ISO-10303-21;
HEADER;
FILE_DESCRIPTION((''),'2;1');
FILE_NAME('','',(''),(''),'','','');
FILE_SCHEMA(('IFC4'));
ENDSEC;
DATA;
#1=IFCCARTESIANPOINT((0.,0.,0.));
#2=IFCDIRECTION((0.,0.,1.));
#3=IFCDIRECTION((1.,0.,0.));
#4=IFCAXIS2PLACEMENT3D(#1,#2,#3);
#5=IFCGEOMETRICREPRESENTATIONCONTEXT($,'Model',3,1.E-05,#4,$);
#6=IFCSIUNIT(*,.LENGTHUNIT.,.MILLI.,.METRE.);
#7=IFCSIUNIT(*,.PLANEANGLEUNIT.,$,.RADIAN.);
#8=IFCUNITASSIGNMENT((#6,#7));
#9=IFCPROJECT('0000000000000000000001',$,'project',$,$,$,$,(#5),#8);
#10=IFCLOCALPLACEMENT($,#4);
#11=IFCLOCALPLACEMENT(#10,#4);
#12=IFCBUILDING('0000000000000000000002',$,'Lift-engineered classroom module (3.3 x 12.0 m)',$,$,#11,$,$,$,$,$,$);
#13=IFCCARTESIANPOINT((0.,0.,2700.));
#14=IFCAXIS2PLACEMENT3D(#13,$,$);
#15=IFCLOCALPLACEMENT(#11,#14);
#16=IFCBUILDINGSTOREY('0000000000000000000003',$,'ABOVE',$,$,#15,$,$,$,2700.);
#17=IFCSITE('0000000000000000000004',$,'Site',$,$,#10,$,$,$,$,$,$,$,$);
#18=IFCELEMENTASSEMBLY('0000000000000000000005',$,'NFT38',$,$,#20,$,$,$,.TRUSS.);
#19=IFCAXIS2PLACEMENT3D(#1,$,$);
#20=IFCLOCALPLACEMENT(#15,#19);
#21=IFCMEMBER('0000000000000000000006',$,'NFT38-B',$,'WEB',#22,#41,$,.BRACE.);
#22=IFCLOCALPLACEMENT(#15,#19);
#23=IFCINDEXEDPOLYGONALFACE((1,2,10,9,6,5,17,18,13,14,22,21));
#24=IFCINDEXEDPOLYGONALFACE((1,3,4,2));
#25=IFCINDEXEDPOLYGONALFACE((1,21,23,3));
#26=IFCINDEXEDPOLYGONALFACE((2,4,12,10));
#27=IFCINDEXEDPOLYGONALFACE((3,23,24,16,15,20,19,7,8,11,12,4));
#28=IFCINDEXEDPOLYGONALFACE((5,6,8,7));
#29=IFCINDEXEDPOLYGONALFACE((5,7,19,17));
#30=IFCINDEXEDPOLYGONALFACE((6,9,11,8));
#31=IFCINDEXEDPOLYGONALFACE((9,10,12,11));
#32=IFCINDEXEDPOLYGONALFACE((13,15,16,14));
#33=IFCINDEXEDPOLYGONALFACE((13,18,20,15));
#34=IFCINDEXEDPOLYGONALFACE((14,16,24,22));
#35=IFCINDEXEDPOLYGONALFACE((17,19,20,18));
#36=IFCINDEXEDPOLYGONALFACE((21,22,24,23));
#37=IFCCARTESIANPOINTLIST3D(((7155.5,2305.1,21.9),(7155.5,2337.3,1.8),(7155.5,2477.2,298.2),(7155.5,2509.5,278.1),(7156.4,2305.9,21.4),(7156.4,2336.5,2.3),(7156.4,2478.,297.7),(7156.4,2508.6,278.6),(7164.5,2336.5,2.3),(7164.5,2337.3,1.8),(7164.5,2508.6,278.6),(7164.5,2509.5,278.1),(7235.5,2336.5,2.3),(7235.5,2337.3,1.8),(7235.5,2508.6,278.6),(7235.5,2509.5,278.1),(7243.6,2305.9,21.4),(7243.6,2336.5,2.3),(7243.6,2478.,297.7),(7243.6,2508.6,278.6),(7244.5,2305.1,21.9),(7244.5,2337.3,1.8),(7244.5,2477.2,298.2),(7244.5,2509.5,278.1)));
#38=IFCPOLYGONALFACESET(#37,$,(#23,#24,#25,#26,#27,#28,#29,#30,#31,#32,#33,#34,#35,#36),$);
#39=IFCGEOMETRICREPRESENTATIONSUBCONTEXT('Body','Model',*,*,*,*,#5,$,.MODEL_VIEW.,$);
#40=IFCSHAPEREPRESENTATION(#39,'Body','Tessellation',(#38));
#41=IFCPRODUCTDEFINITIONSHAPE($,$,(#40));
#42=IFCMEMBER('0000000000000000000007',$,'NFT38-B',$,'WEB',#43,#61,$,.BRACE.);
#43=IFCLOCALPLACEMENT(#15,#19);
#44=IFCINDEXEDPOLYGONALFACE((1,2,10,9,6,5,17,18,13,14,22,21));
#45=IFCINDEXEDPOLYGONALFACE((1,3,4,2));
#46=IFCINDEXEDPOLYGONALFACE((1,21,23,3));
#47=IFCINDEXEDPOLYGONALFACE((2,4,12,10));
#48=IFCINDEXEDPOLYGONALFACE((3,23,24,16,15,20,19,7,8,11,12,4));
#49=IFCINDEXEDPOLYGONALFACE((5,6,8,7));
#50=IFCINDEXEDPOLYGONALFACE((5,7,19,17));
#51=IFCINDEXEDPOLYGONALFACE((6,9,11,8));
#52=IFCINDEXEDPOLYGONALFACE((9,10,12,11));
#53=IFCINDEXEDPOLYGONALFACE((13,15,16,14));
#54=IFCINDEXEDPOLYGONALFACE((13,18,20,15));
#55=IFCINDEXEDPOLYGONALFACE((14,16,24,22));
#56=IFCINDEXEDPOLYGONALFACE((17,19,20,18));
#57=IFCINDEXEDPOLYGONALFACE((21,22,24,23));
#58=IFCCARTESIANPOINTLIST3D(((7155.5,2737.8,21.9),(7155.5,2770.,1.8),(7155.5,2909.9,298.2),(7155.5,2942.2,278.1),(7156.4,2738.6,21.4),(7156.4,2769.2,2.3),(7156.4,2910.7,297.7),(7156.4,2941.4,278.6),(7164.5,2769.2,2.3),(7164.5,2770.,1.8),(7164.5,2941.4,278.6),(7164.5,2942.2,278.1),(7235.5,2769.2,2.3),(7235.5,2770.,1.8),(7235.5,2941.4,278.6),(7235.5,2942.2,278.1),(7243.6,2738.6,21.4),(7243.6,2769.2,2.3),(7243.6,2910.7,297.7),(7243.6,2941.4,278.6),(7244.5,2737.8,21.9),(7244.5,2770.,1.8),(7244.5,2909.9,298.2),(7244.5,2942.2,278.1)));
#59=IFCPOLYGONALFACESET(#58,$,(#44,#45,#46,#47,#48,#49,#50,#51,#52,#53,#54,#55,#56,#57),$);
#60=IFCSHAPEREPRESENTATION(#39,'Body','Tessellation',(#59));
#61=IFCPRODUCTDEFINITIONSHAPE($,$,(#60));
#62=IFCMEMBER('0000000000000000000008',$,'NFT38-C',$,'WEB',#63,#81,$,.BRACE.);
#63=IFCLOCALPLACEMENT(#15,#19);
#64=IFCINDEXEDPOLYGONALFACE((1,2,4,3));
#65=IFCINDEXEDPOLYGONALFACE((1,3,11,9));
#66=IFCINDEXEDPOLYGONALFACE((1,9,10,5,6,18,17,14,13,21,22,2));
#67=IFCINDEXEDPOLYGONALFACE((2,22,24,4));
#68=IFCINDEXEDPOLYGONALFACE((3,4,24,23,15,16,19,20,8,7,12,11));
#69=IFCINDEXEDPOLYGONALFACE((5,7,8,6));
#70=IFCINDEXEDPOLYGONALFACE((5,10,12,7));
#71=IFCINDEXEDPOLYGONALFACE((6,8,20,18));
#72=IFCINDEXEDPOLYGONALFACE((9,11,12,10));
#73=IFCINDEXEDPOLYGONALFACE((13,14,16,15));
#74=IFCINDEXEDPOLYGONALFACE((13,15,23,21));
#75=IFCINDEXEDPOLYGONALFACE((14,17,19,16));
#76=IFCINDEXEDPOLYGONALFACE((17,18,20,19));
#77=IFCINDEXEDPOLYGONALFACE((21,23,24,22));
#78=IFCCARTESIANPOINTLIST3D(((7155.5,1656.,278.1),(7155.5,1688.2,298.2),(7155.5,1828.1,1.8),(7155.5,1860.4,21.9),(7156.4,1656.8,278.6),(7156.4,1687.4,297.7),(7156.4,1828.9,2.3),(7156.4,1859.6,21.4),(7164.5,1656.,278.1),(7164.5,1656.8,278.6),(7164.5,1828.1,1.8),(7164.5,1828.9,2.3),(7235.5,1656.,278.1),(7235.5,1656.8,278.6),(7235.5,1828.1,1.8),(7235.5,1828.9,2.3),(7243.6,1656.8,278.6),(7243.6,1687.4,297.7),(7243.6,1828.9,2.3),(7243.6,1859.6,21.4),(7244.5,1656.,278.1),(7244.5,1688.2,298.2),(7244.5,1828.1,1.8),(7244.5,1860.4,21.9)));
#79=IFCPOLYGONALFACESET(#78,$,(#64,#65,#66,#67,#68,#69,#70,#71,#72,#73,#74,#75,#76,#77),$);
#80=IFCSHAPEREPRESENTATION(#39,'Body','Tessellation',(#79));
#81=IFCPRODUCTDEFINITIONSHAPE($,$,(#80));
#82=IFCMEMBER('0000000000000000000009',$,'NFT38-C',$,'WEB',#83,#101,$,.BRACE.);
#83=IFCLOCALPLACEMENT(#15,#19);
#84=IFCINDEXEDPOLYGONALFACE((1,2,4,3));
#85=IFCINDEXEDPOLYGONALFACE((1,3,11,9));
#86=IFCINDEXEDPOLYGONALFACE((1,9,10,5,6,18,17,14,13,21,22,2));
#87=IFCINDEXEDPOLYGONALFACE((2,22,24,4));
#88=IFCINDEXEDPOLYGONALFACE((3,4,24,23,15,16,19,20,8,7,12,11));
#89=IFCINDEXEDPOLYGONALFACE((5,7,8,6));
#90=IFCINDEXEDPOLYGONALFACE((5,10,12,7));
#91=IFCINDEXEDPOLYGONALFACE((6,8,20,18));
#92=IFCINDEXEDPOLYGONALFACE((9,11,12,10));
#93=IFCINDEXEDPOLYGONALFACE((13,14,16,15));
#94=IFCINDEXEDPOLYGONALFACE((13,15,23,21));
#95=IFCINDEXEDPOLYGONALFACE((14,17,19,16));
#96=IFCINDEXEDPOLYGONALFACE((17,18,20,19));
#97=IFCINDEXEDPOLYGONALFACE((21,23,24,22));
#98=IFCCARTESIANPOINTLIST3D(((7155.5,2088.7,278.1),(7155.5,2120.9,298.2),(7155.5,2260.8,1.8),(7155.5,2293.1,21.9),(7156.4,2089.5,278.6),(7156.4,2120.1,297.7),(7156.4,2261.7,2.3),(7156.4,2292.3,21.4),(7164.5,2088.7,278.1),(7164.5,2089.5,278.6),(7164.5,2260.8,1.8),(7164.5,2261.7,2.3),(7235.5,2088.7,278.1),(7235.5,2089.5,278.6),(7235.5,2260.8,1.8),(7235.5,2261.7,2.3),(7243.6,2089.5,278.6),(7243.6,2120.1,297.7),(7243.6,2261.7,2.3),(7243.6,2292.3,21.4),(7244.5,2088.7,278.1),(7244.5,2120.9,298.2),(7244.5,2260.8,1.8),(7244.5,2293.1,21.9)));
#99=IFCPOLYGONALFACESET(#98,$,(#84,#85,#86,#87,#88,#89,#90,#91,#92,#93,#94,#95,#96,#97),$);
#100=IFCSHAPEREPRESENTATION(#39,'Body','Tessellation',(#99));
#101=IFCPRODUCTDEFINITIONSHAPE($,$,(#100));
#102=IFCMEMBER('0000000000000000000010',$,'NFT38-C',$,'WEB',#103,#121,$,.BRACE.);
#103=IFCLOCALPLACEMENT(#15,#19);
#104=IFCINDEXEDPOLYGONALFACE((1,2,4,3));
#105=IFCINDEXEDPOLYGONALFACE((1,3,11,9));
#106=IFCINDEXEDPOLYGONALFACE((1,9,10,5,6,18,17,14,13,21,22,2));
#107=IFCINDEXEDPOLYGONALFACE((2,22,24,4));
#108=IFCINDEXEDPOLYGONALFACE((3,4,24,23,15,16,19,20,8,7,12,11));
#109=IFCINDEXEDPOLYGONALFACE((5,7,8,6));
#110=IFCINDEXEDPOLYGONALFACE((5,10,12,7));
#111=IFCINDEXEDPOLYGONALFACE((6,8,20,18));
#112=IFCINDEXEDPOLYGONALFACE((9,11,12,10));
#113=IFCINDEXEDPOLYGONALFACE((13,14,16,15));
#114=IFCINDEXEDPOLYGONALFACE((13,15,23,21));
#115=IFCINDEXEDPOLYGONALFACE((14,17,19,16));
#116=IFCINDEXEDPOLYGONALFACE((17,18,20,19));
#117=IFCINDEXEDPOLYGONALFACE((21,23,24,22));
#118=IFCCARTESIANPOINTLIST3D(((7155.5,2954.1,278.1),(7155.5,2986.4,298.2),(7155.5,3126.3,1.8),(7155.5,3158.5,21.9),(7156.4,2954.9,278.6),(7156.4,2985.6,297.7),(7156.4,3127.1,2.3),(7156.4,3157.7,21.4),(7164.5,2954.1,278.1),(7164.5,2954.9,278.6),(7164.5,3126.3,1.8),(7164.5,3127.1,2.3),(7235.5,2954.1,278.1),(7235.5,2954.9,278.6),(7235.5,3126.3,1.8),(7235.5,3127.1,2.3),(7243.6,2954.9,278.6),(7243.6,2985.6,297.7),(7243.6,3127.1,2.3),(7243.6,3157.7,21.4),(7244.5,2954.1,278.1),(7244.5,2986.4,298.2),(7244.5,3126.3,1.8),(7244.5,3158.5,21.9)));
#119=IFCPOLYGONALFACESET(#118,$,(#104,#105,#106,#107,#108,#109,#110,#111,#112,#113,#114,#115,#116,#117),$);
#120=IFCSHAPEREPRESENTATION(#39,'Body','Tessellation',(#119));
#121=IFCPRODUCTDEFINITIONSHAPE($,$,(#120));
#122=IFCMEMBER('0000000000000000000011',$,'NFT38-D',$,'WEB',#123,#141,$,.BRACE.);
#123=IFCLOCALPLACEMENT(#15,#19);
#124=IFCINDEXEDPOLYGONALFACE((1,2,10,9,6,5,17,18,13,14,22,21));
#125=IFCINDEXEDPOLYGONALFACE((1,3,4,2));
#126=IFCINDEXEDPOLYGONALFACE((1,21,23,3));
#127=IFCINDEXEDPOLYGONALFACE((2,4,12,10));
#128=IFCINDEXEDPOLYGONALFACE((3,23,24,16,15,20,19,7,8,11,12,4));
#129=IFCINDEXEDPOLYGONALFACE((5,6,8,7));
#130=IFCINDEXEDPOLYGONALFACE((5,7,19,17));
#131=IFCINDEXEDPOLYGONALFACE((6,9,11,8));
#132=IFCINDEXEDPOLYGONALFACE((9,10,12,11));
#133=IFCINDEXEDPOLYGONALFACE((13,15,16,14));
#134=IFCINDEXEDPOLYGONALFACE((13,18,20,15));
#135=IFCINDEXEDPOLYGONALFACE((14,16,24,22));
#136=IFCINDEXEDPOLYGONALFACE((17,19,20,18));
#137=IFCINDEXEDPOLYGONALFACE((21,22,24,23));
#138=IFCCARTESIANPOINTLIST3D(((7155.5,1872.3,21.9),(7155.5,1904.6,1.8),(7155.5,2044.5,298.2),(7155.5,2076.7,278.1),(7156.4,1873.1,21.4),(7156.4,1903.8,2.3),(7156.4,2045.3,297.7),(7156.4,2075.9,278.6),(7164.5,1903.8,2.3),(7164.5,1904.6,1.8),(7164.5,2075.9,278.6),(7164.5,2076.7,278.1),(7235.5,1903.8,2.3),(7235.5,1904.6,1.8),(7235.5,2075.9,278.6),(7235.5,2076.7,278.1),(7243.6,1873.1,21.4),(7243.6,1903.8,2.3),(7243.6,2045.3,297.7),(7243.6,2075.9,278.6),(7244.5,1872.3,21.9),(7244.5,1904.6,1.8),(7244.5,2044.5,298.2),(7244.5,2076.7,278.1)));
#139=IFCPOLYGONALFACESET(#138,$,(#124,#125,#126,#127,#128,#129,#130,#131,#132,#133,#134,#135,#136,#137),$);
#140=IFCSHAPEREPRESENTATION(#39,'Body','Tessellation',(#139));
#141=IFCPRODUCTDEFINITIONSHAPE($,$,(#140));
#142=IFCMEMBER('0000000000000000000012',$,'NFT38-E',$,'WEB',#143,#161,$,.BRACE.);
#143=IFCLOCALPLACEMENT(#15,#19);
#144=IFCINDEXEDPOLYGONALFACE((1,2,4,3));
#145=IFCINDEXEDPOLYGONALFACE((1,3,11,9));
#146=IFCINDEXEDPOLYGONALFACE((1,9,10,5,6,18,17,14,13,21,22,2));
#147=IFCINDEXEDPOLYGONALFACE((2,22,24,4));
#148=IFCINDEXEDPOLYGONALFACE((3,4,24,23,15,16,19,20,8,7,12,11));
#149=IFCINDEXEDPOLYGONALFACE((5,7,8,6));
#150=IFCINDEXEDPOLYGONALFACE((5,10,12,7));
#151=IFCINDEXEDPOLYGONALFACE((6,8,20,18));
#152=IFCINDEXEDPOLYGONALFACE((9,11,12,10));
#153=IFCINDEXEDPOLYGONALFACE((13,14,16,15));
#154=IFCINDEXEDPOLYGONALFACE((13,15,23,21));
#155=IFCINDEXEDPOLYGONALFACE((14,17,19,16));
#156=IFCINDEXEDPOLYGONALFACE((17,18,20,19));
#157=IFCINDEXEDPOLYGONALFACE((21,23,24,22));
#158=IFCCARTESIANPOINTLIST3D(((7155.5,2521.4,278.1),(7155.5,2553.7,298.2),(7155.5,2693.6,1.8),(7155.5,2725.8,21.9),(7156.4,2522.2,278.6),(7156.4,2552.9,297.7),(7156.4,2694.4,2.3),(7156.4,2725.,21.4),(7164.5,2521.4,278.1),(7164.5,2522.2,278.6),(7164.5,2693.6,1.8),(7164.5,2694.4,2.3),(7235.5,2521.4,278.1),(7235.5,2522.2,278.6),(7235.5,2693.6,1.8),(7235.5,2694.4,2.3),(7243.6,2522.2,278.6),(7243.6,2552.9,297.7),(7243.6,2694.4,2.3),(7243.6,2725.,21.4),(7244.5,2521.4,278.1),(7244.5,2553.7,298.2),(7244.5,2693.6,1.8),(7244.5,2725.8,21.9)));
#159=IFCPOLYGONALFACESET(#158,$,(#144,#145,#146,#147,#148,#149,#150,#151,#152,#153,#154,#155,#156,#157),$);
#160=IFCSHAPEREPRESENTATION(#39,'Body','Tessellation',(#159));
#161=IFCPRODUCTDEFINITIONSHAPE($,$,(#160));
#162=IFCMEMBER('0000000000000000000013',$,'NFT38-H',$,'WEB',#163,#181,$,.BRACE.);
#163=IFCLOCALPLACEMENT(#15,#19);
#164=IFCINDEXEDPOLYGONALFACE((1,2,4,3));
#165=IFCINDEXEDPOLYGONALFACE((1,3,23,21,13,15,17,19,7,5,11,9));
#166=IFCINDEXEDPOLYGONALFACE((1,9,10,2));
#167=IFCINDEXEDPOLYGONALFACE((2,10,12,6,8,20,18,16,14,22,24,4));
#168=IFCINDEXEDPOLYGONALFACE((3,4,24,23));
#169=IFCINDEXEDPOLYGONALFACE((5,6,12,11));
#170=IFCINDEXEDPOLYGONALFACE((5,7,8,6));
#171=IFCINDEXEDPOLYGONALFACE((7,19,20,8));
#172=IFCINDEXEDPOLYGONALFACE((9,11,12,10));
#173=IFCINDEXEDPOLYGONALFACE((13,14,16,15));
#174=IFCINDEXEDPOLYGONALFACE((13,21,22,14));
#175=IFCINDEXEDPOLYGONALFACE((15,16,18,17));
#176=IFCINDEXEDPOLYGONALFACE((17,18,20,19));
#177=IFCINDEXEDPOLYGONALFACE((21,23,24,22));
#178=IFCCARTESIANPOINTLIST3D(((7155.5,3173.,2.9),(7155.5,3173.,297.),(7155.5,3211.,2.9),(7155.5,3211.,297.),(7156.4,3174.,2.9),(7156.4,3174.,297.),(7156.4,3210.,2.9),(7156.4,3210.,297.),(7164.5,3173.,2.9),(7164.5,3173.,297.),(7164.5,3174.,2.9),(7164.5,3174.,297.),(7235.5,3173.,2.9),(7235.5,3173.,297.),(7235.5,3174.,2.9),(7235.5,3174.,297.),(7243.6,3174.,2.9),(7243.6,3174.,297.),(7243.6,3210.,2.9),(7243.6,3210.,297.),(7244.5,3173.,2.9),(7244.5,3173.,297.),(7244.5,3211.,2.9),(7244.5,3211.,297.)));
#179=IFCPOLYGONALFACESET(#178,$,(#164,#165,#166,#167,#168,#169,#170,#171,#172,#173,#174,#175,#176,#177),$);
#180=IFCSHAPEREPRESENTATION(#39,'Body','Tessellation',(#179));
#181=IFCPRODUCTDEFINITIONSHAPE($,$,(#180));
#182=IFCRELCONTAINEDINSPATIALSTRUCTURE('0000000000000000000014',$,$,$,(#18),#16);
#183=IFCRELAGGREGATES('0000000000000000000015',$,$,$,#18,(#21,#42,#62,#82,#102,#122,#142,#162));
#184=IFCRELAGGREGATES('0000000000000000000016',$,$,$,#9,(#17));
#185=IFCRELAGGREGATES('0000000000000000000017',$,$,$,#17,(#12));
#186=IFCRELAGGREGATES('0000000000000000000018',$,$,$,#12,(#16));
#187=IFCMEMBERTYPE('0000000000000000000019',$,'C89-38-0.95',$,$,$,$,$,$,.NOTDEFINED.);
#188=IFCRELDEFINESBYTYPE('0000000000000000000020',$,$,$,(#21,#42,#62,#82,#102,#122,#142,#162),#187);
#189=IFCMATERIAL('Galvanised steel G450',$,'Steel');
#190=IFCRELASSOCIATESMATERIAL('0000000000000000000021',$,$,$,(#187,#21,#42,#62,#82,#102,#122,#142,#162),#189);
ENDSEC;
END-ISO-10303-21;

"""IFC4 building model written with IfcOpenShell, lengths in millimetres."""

from ifc_helpers import new_model, si_unit, frame, origin, origin_with_axes, origin_2d, place, context, subcontext, project, spatial, c_section, extrude, material, material_profile, profile_set, profile_usage, type_object, element, aggregate, save


model = new_model("IFC4")

# Units and contexts
model_context = context("Model", 3, precision=1e-05, world=origin_with_axes())
body_context = subcontext(model_context, "Body", "Model", "MODEL_VIEW")
ifc_project = project(units=[si_unit("LENGTHUNIT", "METRE", prefix="MILLI"), si_unit("PLANEANGLEUNIT", "RADIAN")], contexts=[model_context])

# Site, building, storey
site_placement = place(None, origin_with_axes())
site = spatial("IfcSite", under=ifc_project, at=site_placement, Name="Site")
building_placement = place(site_placement, origin_with_axes())
building = spatial("IfcBuilding", under=site, at=building_placement, Name="Lift-engineered classroom module (3.3 x 12.0 m)")
storey_placement = place(building_placement, frame((0.0, 0.0, 2700.0)))
storey = spatial("IfcBuildingStorey", under=building, at=storey_placement, Name="ABOVE", Elevation=2700.0)

# Element assembly, members
ifc_material = material(Name="Galvanised steel G450", Category="Steel")
ifc_material_profile_1 = material_profile(ifc_material, c_section(Depth=89.0, Width=38.0, WallThickness=0.9, Girth=9.0, at=origin_2d()), Name="C89-38-0.95")
ifc_profile_set_1 = profile_set([ifc_material_profile_1], Name="C89-38-0.95")
ifc_profile_usage_1 = profile_usage(ifc_profile_set_1)
member_type_1 = type_object("IfcMemberType", Name="C89-38-0.95", PredefinedType="NOTDEFINED", material=ifc_profile_set_1)
assembly_1_placement = place(storey_placement, frame((7200.0, 89.0, 0.0)))
assembly_1 = element("IfcElementAssembly", 1, at=assembly_1_placement, inside=storey, Name="NFT38", PredefinedType="TRUSS")
member_1_placement = place(assembly_1_placement, frame((0.0, 2232.2, 11.8), z_axis=(0.0, 0.528797, 0.848748), x_axis=(0.0, 0.848748, -0.528797)))
member_1 = element("IfcMember", 2, at=member_1_placement, type_object=member_type_1, material=ifc_profile_usage_1, Name="NFT38-B", ObjectType="WEB", PredefinedType="BRACE", context=body_context, shape_type="SweptSolid", body=[
    extrude(c_section(Depth=89.0, Width=38.0, WallThickness=0.9, Girth=9.0, at=origin_2d()), origin(), (0.0, 0.0, 1.0), 325.6),
])
member_2_placement = place(assembly_1_placement, frame((0.0, 2664.9, 11.8), z_axis=(0.0, 0.528797, 0.848748), x_axis=(0.0, 0.848748, -0.528797)))
member_2 = element("IfcMember", 3, at=member_2_placement, type_object=member_type_1, material=ifc_profile_usage_1, Name="NFT38-B", ObjectType="WEB", PredefinedType="BRACE", context=body_context, shape_type="SweptSolid", body=[
    extrude(c_section(Depth=89.0, Width=38.0, WallThickness=0.9, Girth=9.0, at=origin_2d()), origin(), (0.0, 0.0, 1.0), 325.6),
])
member_3_placement = place(assembly_1_placement, frame((0.0, 1755.3, 11.8), z_axis=(0.0, -0.528797, 0.848748), x_axis=(0.0, -0.848748, -0.528797)))
member_3 = element("IfcMember", 4, at=member_3_placement, type_object=member_type_1, material=ifc_profile_usage_1, Name="NFT38-C", ObjectType="WEB", PredefinedType="BRACE", context=body_context, shape_type="SweptSolid", body=[
    extrude(c_section(Depth=89.0, Width=38.0, WallThickness=0.9, Girth=9.0, at=origin_2d()), origin(), (0.0, 0.0, 1.0), 325.6),
])
member_4_placement = place(assembly_1_placement, frame((0.0, 2188.0, 11.8), z_axis=(0.0, -0.528797, 0.848748), x_axis=(0.0, -0.848748, -0.528797)))
member_4 = element("IfcMember", 5, at=member_4_placement, type_object=member_type_1, material=ifc_profile_usage_1, Name="NFT38-C", ObjectType="WEB", PredefinedType="BRACE", context=body_context, shape_type="SweptSolid", body=[
    extrude(c_section(Depth=89.0, Width=38.0, WallThickness=0.9, Girth=9.0, at=origin_2d()), origin(), (0.0, 0.0, 1.0), 325.6),
])
member_5_placement = place(assembly_1_placement, frame((0.0, 3053.4, 11.8), z_axis=(0.0, -0.528797, 0.848748), x_axis=(0.0, -0.848748, -0.528797)))
member_5 = element("IfcMember", 6, at=member_5_placement, type_object=member_type_1, material=ifc_profile_usage_1, Name="NFT38-C", ObjectType="WEB", PredefinedType="BRACE", context=body_context, shape_type="SweptSolid", body=[
    extrude(c_section(Depth=89.0, Width=38.0, WallThickness=0.9, Girth=9.0, at=origin_2d()), origin(), (0.0, 0.0, 1.0), 325.6),
])
member_6_placement = place(assembly_1_placement, frame((0.0, 1799.5, 11.8), z_axis=(0.0, 0.528775, 0.848762), x_axis=(0.0, 0.848762, -0.528775)))
member_6 = element("IfcMember", 7, at=member_6_placement, type_object=member_type_1, material=ifc_profile_usage_1, Name="NFT38-D", ObjectType="WEB", PredefinedType="BRACE", context=body_context, shape_type="SweptSolid", body=[
    extrude(c_section(Depth=89.0, Width=38.0, WallThickness=0.9, Girth=9.0, at=origin_2d()), origin(), (0.0, 0.0, 1.0), 325.6),
])
member_7_placement = place(assembly_1_placement, frame((0.0, 2620.7, 11.8), z_axis=(0.0, -0.528775, 0.848762), x_axis=(0.0, -0.848762, -0.528775)))
member_7 = element("IfcMember", 8, at=member_7_placement, type_object=member_type_1, material=ifc_profile_usage_1, Name="NFT38-E", ObjectType="WEB", PredefinedType="BRACE", context=body_context, shape_type="SweptSolid", body=[
    extrude(c_section(Depth=89.0, Width=38.0, WallThickness=0.9, Girth=9.0, at=origin_2d()), origin(), (0.0, 0.0, 1.0), 325.6),
])
member_8_placement = place(assembly_1_placement, frame((0.0, 3103.0, 2.9), z_axis=(0.0, 0.0, 1.0), x_axis=(0.0, -1.0, 0.0)))
member_8 = element("IfcMember", 9, at=member_8_placement, type_object=member_type_1, material=ifc_profile_usage_1, Name="NFT38-H", ObjectType="WEB", PredefinedType="BRACE", context=body_context, shape_type="SweptSolid", body=[
    extrude(c_section(Depth=89.0, Width=38.0, WallThickness=0.9, Girth=9.0, at=origin_2d()), origin(), (0.0, 0.0, 1.0), 294.1),
])
aggregate(assembly_1, [member_1, member_2, member_3, member_4, member_5, member_6, member_7, member_8])

save(model, "model.ifc")
